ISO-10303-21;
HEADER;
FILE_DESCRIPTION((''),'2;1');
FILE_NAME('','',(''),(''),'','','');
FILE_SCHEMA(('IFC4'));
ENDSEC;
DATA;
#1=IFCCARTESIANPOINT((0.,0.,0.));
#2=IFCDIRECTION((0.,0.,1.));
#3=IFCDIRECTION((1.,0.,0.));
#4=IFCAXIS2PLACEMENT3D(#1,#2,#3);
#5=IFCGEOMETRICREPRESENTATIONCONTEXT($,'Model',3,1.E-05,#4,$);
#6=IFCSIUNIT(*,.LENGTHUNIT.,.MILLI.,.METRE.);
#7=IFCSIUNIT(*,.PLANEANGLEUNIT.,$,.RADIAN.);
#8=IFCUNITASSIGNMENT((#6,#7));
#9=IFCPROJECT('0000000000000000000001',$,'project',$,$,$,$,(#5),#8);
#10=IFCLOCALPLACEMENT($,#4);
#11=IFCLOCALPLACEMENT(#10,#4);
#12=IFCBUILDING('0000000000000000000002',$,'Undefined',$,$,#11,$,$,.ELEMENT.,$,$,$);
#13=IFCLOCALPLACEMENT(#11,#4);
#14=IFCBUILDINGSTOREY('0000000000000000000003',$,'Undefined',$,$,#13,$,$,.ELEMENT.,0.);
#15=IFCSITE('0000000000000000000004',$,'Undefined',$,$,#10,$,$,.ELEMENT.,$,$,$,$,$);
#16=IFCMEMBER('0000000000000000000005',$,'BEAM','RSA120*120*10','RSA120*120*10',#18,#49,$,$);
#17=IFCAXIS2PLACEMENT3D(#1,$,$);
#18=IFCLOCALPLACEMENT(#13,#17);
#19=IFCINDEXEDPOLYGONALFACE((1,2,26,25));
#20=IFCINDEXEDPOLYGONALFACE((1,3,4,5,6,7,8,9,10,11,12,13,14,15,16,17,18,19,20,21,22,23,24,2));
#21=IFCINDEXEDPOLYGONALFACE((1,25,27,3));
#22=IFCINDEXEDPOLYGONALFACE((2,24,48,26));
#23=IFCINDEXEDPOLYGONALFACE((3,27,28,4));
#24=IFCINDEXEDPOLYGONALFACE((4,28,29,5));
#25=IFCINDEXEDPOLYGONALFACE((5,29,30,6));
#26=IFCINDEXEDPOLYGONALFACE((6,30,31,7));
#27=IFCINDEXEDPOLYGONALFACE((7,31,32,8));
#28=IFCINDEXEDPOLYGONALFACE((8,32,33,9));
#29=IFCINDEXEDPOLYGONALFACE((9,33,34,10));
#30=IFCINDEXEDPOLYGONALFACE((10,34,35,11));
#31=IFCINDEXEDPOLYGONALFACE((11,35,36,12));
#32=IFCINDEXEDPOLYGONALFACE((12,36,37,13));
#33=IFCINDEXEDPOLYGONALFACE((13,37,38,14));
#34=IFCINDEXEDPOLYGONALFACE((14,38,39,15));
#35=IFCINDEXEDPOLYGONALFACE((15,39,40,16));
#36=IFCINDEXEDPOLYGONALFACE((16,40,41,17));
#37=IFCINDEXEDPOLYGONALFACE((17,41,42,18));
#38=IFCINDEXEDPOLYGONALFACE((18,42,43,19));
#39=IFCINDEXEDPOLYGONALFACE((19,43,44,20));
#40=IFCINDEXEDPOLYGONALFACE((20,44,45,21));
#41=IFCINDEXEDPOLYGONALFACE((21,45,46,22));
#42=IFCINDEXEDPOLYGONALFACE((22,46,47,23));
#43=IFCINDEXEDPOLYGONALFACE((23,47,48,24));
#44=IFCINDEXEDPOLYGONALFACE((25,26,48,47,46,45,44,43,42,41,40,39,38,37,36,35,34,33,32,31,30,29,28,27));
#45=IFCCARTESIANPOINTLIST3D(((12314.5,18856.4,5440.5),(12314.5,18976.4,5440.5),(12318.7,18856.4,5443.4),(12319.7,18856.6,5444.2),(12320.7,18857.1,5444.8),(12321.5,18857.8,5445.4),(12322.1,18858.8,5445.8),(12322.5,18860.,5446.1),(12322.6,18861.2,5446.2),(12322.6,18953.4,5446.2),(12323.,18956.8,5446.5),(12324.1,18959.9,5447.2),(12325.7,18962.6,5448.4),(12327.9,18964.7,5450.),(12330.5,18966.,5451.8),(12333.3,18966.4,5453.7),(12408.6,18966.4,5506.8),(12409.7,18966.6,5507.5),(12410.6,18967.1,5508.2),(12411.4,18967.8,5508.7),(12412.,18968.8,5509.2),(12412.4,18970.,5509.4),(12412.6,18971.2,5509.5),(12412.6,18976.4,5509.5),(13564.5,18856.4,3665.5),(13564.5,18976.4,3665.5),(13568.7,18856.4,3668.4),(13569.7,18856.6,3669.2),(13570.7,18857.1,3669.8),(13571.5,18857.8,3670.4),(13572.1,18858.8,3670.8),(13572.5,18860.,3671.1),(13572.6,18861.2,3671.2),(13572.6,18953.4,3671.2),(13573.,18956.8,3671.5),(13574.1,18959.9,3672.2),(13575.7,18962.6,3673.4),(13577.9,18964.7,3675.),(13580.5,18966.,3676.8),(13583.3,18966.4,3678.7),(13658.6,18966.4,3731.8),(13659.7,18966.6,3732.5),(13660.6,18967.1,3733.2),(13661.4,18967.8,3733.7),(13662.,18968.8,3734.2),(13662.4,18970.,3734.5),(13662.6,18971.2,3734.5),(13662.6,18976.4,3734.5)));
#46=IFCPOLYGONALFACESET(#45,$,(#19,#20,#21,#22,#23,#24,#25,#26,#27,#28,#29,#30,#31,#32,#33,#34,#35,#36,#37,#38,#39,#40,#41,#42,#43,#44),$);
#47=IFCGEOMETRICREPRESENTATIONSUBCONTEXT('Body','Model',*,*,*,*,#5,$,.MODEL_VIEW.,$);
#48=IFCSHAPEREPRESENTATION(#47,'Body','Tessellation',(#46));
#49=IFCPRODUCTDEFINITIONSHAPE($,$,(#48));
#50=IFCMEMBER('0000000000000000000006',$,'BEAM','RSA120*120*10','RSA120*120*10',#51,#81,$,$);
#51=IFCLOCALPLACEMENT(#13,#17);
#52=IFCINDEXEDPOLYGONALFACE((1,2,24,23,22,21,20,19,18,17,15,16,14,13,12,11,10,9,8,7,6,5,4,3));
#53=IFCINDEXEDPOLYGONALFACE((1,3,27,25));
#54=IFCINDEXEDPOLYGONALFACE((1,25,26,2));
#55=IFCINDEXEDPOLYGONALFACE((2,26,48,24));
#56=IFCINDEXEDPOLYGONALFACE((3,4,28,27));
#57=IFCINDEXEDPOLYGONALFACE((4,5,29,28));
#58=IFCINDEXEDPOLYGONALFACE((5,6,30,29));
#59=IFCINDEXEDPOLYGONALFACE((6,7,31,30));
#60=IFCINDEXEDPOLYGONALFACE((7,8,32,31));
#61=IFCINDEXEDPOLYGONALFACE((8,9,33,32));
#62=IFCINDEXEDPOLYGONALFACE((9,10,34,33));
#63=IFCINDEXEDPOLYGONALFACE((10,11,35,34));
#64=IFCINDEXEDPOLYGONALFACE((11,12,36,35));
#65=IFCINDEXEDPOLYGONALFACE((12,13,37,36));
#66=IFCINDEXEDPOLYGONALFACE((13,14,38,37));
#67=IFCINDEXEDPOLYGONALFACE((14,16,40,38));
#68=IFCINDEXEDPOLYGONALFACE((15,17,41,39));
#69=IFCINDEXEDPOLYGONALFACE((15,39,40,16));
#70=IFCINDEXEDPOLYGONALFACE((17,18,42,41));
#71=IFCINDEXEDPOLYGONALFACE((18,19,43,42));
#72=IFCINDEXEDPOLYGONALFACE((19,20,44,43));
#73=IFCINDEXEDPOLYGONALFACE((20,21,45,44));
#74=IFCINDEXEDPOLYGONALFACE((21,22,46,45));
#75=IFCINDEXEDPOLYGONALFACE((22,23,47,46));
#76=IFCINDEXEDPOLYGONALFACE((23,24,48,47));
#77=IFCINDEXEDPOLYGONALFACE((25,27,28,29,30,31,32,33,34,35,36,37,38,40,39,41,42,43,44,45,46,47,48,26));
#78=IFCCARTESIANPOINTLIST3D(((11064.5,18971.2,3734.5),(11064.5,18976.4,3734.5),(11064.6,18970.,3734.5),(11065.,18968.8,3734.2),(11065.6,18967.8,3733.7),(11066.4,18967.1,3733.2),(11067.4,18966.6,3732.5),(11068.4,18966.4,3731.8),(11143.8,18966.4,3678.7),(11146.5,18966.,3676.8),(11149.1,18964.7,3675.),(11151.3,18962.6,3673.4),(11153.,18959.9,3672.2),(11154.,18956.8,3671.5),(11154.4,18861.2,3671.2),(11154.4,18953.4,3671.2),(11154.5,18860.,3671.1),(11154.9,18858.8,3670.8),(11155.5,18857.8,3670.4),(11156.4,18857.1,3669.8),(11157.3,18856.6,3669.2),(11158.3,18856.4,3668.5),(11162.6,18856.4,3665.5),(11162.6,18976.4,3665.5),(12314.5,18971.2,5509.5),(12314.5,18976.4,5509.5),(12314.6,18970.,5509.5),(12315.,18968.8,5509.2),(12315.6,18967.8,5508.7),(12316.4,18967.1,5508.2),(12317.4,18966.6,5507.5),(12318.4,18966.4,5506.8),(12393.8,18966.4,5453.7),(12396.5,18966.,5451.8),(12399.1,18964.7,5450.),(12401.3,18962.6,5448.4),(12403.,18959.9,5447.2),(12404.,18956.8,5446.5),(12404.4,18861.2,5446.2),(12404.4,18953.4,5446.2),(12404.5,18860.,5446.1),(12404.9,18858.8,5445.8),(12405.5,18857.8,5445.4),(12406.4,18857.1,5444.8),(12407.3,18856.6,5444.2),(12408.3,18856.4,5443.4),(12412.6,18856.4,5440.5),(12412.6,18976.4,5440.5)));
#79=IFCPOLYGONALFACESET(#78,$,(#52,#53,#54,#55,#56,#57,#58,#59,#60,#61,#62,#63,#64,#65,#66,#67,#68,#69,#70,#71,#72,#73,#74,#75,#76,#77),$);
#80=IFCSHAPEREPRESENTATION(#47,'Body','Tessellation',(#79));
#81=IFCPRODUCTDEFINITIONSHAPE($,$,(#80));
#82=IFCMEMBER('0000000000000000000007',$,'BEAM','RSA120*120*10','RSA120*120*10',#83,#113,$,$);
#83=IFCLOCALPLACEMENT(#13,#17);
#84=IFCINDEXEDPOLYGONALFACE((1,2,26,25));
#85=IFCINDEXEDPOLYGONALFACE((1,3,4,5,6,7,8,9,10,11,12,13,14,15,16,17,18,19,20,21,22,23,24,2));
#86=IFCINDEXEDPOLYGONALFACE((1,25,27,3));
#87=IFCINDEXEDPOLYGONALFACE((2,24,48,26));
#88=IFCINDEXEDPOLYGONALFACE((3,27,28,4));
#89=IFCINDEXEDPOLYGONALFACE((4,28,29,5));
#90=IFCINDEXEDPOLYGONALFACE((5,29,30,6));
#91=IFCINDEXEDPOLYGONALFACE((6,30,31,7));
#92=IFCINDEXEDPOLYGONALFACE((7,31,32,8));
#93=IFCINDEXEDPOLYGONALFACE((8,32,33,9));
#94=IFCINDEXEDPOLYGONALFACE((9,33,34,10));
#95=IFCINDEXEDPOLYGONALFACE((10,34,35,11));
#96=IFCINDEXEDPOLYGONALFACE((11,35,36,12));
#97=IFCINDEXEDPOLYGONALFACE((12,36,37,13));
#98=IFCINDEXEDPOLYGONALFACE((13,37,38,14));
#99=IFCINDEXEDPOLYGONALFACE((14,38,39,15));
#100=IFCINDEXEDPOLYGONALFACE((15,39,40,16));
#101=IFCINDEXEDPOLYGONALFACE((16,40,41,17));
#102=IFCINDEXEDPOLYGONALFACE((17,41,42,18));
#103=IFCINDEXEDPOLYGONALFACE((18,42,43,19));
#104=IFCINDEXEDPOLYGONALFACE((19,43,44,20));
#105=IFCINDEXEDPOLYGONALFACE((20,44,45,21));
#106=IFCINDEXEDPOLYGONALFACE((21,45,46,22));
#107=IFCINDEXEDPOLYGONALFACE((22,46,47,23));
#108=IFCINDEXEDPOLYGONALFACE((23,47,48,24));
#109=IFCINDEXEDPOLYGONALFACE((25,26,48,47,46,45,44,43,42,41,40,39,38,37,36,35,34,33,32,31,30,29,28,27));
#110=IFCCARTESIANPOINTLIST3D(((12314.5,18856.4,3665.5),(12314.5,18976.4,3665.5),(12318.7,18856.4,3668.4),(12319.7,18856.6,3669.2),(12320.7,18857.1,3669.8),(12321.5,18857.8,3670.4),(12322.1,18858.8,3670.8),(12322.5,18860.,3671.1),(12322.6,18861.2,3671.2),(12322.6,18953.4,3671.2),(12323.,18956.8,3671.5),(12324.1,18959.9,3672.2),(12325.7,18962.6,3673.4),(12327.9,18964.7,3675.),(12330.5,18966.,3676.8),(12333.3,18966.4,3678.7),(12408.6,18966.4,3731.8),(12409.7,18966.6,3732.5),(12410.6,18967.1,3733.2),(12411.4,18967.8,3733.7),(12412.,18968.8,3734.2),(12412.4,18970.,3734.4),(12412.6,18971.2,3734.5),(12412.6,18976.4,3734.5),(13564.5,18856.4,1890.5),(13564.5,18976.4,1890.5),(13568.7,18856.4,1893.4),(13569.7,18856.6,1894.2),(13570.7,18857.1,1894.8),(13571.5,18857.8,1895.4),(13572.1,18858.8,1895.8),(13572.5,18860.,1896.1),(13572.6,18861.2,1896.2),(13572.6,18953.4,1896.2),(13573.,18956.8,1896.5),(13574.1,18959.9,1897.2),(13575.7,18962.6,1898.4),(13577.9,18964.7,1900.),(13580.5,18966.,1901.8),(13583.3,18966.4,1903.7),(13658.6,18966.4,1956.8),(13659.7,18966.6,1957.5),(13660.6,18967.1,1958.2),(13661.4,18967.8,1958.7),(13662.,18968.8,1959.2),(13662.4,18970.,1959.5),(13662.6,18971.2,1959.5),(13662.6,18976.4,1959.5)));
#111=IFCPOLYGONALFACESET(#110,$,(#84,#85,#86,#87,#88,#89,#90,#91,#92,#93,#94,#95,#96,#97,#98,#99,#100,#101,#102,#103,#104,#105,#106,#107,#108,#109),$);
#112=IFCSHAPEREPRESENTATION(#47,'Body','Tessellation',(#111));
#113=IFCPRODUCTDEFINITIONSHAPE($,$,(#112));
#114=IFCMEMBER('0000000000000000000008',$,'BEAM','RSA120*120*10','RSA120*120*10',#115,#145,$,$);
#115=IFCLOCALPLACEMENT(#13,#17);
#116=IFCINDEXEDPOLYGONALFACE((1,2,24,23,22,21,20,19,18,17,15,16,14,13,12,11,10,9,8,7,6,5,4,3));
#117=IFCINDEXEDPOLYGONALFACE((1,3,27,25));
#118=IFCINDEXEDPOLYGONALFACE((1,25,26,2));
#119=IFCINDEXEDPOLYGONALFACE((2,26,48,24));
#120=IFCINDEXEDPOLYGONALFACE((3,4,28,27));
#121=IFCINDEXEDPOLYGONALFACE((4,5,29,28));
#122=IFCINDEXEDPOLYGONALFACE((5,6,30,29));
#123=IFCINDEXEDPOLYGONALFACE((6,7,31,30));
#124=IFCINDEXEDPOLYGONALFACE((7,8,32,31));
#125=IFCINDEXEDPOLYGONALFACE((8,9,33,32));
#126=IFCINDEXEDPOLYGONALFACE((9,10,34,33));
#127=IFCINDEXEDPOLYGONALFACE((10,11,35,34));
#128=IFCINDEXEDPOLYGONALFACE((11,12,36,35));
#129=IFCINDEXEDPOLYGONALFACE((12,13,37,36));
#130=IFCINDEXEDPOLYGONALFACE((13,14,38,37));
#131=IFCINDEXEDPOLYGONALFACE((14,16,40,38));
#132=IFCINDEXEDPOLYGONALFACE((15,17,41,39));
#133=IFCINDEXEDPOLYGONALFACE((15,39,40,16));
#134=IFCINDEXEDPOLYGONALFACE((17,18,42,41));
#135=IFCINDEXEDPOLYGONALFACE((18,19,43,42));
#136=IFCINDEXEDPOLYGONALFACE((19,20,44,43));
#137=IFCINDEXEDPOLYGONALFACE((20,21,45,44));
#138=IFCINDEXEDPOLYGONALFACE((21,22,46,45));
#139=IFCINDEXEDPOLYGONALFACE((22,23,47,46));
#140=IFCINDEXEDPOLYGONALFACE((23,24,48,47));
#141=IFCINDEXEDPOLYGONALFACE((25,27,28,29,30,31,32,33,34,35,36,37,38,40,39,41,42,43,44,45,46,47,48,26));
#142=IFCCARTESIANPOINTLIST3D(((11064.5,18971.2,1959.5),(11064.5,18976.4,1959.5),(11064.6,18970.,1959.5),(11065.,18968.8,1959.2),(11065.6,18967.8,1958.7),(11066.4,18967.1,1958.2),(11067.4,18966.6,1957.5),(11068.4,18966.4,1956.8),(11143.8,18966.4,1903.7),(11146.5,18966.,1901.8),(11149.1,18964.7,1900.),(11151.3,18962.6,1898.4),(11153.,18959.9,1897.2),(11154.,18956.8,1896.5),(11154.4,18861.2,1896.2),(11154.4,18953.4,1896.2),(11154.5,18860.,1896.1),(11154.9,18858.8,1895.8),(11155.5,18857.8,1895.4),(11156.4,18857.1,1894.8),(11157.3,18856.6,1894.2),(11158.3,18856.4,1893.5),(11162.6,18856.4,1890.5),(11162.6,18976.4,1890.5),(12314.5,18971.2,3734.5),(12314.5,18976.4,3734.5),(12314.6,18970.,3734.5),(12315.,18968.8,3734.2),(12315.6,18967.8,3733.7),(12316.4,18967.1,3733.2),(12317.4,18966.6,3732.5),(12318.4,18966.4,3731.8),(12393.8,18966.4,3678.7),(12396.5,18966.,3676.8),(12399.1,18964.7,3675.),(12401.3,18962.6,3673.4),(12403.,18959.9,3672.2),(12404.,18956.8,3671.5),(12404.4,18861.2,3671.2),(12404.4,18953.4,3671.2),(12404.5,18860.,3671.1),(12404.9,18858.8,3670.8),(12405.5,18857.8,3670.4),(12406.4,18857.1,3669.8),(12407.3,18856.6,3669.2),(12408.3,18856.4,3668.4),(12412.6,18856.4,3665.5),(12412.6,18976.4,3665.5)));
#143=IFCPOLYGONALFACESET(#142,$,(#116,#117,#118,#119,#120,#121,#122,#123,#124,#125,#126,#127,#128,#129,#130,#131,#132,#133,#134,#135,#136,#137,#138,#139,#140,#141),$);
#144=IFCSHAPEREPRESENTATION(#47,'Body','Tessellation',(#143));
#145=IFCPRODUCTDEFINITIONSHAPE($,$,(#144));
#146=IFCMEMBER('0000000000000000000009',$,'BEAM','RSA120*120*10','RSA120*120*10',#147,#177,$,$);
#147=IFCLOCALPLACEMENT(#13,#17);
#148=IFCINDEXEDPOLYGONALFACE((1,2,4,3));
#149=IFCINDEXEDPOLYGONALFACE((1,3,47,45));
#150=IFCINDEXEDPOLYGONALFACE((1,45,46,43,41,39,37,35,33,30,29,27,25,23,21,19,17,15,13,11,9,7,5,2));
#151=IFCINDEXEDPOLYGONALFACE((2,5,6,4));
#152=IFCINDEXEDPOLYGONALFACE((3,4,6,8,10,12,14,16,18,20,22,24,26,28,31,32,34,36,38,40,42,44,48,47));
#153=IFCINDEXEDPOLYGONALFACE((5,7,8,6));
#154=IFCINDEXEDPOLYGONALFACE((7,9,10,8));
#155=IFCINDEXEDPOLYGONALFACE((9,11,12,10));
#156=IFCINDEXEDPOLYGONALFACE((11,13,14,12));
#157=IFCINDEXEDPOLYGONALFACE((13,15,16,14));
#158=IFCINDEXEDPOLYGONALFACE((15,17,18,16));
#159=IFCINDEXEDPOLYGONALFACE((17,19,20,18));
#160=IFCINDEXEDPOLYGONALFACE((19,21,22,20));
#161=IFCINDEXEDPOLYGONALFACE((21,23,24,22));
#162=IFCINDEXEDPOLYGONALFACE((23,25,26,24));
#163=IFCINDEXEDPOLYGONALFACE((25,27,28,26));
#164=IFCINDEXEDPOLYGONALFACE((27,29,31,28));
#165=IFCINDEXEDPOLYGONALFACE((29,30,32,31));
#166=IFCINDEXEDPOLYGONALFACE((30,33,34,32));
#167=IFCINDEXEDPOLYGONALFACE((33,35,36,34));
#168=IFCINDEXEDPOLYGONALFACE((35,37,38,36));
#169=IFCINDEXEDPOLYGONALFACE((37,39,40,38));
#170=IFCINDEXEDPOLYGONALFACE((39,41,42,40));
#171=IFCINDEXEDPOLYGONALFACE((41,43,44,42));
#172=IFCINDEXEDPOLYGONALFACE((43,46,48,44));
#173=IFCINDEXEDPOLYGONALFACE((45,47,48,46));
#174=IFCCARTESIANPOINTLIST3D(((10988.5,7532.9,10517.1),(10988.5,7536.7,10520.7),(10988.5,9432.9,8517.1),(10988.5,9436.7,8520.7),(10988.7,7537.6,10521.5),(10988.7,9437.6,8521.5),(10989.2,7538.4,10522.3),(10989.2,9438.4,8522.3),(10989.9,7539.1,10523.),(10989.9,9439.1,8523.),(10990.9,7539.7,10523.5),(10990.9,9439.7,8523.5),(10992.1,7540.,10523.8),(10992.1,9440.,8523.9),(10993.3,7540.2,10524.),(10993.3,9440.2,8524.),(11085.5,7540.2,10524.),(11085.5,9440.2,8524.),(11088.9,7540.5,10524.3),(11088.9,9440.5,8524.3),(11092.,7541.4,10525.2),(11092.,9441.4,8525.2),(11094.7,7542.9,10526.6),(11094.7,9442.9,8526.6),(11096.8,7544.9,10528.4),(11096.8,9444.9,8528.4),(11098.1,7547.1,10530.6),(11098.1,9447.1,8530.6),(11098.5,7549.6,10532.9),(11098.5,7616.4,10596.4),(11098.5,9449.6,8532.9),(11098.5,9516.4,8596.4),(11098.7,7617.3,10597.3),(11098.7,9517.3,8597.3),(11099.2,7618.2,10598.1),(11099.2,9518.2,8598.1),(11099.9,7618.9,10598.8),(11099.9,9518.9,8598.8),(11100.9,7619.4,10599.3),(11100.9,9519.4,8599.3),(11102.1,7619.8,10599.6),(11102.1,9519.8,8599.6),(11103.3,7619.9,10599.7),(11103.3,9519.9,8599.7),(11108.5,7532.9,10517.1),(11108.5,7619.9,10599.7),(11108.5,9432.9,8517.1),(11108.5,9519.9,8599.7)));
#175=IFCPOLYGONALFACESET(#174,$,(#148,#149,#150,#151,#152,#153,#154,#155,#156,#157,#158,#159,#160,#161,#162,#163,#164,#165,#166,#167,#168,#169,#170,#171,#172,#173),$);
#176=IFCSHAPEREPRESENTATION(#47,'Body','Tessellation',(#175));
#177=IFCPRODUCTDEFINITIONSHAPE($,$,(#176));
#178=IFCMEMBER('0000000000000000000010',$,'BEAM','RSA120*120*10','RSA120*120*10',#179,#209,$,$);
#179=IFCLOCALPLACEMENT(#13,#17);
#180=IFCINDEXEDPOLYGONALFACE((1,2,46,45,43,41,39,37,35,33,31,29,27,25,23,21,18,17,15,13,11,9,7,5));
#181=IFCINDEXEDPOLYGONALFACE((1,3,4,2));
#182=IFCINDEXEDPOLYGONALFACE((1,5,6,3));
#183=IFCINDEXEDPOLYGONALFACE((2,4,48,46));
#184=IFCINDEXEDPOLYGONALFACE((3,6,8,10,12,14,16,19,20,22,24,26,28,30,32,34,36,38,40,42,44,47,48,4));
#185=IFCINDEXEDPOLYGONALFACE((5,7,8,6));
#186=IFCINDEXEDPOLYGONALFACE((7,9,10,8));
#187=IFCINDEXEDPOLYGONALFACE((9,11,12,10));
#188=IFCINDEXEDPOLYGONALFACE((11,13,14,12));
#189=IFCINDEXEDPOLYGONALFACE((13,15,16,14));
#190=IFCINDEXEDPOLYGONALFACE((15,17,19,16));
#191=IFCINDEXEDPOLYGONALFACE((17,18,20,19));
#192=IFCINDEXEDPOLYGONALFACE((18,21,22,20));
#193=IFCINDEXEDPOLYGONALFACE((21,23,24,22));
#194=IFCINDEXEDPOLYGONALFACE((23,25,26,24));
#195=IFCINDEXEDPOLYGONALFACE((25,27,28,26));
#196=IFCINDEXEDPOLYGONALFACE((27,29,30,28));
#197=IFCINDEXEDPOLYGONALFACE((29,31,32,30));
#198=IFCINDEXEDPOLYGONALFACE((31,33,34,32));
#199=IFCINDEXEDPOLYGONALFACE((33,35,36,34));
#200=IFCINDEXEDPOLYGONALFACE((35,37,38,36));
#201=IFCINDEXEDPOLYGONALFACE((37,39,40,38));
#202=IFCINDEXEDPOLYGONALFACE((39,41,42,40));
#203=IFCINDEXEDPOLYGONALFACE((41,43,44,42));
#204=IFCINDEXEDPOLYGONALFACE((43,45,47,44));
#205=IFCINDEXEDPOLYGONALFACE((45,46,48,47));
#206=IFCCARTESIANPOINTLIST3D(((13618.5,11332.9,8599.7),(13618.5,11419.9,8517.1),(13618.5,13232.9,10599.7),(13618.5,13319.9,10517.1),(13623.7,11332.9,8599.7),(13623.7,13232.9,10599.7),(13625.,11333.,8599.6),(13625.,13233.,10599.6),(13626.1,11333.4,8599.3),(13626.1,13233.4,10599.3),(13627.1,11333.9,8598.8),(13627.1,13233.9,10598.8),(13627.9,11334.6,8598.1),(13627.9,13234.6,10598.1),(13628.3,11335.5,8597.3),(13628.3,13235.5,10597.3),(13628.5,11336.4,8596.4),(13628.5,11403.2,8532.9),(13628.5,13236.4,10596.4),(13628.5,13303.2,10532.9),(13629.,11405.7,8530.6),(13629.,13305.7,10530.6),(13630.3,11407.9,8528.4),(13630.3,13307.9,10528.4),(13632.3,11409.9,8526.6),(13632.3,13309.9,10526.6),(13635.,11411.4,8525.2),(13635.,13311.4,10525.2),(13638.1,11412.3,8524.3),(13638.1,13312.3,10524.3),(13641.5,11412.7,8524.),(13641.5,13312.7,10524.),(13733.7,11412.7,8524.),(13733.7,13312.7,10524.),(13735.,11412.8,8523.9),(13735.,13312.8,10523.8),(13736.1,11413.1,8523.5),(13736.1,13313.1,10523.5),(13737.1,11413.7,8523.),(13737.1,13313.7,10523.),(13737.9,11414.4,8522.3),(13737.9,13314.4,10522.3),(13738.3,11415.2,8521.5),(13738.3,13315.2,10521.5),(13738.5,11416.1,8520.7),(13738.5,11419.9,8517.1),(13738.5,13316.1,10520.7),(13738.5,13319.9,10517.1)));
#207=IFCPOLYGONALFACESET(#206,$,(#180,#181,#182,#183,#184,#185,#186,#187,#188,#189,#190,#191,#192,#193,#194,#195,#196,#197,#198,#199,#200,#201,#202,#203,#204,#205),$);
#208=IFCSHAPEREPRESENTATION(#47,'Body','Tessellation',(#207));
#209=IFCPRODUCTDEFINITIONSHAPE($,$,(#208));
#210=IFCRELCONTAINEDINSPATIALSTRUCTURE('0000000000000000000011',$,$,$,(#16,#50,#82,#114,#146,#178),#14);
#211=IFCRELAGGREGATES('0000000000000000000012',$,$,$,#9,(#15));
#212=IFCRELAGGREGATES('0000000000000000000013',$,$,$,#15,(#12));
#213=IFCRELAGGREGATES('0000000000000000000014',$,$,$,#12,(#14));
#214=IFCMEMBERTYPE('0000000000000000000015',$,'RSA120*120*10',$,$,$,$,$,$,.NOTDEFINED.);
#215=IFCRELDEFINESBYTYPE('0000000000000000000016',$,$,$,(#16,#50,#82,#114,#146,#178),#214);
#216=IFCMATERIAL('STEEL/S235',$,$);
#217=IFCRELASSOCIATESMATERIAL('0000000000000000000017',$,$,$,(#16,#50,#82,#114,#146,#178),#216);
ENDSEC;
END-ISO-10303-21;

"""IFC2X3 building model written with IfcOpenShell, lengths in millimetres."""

from ifc_helpers import new_model, si_unit, frame, origin_with_axes, origin_2d_with_axis, place, context, subcontext, project, spatial, l_section, extrude, material, type_object, element, save


model = new_model("IFC2X3")

# Units and contexts
model_context = context("Model", 3, precision=1e-05, world=origin_with_axes())
body_context = subcontext(model_context, "Body", "Model", "MODEL_VIEW")
ifc_project = project(units=[si_unit("LENGTHUNIT", "METRE", prefix="MILLI"), si_unit("PLANEANGLEUNIT", "RADIAN")], contexts=[model_context])

# Site, building, storey
site_placement = place(None, origin_with_axes())
site = spatial("IfcSite", under=ifc_project, at=site_placement, Name="Undefined", CompositionType="ELEMENT")
building_placement = place(site_placement, origin_with_axes())
building = spatial("IfcBuilding", under=site, at=building_placement, Name="Undefined", CompositionType="ELEMENT")
storey_placement = place(building_placement, origin_with_axes())
storey = spatial("IfcBuildingStorey", under=building, at=storey_placement, Name="Undefined", CompositionType="ELEMENT", Elevation=0.0)

# Shared definitions
ifc_material = material(Name="STEEL/S235")

# Members
member_type_1 = type_object("IfcMemberType", Name="RSA120*120*10", PredefinedType="NOTDEFINED")
for number, where, z_axis, x_axis, name in (
    (1, (12363.5, 18916.4, 5475.0), (0.817606, 0.0, 0.575779), (0.575779, 0.0, -0.817606), "BEAM"),
    (2, (11113.5, 18916.4, 3700.0), (-0.817606, 0.0, 0.575779), (0.575779, 0.0, 0.817606), "BEAM"),
    (3, (12363.5, 18916.4, 3700.0), (0.817606, 0.0, 0.575779), (0.575779, 0.0, -0.817606), "BEAM"),
    (4, (11113.5, 18916.4, 1925.0), (-0.817606, 0.0, 0.575779), (0.575779, 0.0, 0.817606), "BEAM"),
):
    element("IfcMember", number, at=place(storey_placement, frame(where, z_axis=z_axis, x_axis=x_axis)), inside=storey, type_object=member_type_1, material=ifc_material, Name=name, Description="RSA120*120*10", ObjectType="RSA120*120*10", context=body_context, shape_type="SweptSolid", body=[
        extrude(l_section(Depth=120.0, Width=120.0, Thickness=10.0, FilletRadius=13.0, EdgeRadius=4.8, at=origin_2d_with_axis()), frame((2171.0, 0.0, 0.0), z_axis=(-1.0, 0.0, 0.0), x_axis=(0.0, -1.0, 0.0)), (0.0, 0.0, 1.0), 2171.0),
    ])
for number, where, z_axis, x_axis, name in (
    (5, (11048.5, 9476.4, 8558.4), (0.0, 0.724999, 0.688749), (0.0, -0.688749, 0.724999), "BEAM"),
    (6, (13678.5, 11376.4, 8558.4), (0.0, -0.724999, 0.688749), (0.0, 0.688749, 0.724999), "BEAM"),
):
    element("IfcMember", number, at=place(storey_placement, frame(where, z_axis=z_axis, x_axis=x_axis)), inside=storey, type_object=member_type_1, material=ifc_material, Name=name, Description="RSA120*120*10", ObjectType="RSA120*120*10", context=body_context, shape_type="SweptSolid", body=[
        extrude(l_section(Depth=120.0, Width=120.0, Thickness=10.0, FilletRadius=13.0, EdgeRadius=4.8, at=origin_2d_with_axis()), frame((2758.6, 0.0, 0.0), z_axis=(-1.0, 0.0, 0.0), x_axis=(0.0, -1.0, 0.0)), (0.0, 0.0, 1.0), 2758.6),
    ])

save(model, "model.ifc")
